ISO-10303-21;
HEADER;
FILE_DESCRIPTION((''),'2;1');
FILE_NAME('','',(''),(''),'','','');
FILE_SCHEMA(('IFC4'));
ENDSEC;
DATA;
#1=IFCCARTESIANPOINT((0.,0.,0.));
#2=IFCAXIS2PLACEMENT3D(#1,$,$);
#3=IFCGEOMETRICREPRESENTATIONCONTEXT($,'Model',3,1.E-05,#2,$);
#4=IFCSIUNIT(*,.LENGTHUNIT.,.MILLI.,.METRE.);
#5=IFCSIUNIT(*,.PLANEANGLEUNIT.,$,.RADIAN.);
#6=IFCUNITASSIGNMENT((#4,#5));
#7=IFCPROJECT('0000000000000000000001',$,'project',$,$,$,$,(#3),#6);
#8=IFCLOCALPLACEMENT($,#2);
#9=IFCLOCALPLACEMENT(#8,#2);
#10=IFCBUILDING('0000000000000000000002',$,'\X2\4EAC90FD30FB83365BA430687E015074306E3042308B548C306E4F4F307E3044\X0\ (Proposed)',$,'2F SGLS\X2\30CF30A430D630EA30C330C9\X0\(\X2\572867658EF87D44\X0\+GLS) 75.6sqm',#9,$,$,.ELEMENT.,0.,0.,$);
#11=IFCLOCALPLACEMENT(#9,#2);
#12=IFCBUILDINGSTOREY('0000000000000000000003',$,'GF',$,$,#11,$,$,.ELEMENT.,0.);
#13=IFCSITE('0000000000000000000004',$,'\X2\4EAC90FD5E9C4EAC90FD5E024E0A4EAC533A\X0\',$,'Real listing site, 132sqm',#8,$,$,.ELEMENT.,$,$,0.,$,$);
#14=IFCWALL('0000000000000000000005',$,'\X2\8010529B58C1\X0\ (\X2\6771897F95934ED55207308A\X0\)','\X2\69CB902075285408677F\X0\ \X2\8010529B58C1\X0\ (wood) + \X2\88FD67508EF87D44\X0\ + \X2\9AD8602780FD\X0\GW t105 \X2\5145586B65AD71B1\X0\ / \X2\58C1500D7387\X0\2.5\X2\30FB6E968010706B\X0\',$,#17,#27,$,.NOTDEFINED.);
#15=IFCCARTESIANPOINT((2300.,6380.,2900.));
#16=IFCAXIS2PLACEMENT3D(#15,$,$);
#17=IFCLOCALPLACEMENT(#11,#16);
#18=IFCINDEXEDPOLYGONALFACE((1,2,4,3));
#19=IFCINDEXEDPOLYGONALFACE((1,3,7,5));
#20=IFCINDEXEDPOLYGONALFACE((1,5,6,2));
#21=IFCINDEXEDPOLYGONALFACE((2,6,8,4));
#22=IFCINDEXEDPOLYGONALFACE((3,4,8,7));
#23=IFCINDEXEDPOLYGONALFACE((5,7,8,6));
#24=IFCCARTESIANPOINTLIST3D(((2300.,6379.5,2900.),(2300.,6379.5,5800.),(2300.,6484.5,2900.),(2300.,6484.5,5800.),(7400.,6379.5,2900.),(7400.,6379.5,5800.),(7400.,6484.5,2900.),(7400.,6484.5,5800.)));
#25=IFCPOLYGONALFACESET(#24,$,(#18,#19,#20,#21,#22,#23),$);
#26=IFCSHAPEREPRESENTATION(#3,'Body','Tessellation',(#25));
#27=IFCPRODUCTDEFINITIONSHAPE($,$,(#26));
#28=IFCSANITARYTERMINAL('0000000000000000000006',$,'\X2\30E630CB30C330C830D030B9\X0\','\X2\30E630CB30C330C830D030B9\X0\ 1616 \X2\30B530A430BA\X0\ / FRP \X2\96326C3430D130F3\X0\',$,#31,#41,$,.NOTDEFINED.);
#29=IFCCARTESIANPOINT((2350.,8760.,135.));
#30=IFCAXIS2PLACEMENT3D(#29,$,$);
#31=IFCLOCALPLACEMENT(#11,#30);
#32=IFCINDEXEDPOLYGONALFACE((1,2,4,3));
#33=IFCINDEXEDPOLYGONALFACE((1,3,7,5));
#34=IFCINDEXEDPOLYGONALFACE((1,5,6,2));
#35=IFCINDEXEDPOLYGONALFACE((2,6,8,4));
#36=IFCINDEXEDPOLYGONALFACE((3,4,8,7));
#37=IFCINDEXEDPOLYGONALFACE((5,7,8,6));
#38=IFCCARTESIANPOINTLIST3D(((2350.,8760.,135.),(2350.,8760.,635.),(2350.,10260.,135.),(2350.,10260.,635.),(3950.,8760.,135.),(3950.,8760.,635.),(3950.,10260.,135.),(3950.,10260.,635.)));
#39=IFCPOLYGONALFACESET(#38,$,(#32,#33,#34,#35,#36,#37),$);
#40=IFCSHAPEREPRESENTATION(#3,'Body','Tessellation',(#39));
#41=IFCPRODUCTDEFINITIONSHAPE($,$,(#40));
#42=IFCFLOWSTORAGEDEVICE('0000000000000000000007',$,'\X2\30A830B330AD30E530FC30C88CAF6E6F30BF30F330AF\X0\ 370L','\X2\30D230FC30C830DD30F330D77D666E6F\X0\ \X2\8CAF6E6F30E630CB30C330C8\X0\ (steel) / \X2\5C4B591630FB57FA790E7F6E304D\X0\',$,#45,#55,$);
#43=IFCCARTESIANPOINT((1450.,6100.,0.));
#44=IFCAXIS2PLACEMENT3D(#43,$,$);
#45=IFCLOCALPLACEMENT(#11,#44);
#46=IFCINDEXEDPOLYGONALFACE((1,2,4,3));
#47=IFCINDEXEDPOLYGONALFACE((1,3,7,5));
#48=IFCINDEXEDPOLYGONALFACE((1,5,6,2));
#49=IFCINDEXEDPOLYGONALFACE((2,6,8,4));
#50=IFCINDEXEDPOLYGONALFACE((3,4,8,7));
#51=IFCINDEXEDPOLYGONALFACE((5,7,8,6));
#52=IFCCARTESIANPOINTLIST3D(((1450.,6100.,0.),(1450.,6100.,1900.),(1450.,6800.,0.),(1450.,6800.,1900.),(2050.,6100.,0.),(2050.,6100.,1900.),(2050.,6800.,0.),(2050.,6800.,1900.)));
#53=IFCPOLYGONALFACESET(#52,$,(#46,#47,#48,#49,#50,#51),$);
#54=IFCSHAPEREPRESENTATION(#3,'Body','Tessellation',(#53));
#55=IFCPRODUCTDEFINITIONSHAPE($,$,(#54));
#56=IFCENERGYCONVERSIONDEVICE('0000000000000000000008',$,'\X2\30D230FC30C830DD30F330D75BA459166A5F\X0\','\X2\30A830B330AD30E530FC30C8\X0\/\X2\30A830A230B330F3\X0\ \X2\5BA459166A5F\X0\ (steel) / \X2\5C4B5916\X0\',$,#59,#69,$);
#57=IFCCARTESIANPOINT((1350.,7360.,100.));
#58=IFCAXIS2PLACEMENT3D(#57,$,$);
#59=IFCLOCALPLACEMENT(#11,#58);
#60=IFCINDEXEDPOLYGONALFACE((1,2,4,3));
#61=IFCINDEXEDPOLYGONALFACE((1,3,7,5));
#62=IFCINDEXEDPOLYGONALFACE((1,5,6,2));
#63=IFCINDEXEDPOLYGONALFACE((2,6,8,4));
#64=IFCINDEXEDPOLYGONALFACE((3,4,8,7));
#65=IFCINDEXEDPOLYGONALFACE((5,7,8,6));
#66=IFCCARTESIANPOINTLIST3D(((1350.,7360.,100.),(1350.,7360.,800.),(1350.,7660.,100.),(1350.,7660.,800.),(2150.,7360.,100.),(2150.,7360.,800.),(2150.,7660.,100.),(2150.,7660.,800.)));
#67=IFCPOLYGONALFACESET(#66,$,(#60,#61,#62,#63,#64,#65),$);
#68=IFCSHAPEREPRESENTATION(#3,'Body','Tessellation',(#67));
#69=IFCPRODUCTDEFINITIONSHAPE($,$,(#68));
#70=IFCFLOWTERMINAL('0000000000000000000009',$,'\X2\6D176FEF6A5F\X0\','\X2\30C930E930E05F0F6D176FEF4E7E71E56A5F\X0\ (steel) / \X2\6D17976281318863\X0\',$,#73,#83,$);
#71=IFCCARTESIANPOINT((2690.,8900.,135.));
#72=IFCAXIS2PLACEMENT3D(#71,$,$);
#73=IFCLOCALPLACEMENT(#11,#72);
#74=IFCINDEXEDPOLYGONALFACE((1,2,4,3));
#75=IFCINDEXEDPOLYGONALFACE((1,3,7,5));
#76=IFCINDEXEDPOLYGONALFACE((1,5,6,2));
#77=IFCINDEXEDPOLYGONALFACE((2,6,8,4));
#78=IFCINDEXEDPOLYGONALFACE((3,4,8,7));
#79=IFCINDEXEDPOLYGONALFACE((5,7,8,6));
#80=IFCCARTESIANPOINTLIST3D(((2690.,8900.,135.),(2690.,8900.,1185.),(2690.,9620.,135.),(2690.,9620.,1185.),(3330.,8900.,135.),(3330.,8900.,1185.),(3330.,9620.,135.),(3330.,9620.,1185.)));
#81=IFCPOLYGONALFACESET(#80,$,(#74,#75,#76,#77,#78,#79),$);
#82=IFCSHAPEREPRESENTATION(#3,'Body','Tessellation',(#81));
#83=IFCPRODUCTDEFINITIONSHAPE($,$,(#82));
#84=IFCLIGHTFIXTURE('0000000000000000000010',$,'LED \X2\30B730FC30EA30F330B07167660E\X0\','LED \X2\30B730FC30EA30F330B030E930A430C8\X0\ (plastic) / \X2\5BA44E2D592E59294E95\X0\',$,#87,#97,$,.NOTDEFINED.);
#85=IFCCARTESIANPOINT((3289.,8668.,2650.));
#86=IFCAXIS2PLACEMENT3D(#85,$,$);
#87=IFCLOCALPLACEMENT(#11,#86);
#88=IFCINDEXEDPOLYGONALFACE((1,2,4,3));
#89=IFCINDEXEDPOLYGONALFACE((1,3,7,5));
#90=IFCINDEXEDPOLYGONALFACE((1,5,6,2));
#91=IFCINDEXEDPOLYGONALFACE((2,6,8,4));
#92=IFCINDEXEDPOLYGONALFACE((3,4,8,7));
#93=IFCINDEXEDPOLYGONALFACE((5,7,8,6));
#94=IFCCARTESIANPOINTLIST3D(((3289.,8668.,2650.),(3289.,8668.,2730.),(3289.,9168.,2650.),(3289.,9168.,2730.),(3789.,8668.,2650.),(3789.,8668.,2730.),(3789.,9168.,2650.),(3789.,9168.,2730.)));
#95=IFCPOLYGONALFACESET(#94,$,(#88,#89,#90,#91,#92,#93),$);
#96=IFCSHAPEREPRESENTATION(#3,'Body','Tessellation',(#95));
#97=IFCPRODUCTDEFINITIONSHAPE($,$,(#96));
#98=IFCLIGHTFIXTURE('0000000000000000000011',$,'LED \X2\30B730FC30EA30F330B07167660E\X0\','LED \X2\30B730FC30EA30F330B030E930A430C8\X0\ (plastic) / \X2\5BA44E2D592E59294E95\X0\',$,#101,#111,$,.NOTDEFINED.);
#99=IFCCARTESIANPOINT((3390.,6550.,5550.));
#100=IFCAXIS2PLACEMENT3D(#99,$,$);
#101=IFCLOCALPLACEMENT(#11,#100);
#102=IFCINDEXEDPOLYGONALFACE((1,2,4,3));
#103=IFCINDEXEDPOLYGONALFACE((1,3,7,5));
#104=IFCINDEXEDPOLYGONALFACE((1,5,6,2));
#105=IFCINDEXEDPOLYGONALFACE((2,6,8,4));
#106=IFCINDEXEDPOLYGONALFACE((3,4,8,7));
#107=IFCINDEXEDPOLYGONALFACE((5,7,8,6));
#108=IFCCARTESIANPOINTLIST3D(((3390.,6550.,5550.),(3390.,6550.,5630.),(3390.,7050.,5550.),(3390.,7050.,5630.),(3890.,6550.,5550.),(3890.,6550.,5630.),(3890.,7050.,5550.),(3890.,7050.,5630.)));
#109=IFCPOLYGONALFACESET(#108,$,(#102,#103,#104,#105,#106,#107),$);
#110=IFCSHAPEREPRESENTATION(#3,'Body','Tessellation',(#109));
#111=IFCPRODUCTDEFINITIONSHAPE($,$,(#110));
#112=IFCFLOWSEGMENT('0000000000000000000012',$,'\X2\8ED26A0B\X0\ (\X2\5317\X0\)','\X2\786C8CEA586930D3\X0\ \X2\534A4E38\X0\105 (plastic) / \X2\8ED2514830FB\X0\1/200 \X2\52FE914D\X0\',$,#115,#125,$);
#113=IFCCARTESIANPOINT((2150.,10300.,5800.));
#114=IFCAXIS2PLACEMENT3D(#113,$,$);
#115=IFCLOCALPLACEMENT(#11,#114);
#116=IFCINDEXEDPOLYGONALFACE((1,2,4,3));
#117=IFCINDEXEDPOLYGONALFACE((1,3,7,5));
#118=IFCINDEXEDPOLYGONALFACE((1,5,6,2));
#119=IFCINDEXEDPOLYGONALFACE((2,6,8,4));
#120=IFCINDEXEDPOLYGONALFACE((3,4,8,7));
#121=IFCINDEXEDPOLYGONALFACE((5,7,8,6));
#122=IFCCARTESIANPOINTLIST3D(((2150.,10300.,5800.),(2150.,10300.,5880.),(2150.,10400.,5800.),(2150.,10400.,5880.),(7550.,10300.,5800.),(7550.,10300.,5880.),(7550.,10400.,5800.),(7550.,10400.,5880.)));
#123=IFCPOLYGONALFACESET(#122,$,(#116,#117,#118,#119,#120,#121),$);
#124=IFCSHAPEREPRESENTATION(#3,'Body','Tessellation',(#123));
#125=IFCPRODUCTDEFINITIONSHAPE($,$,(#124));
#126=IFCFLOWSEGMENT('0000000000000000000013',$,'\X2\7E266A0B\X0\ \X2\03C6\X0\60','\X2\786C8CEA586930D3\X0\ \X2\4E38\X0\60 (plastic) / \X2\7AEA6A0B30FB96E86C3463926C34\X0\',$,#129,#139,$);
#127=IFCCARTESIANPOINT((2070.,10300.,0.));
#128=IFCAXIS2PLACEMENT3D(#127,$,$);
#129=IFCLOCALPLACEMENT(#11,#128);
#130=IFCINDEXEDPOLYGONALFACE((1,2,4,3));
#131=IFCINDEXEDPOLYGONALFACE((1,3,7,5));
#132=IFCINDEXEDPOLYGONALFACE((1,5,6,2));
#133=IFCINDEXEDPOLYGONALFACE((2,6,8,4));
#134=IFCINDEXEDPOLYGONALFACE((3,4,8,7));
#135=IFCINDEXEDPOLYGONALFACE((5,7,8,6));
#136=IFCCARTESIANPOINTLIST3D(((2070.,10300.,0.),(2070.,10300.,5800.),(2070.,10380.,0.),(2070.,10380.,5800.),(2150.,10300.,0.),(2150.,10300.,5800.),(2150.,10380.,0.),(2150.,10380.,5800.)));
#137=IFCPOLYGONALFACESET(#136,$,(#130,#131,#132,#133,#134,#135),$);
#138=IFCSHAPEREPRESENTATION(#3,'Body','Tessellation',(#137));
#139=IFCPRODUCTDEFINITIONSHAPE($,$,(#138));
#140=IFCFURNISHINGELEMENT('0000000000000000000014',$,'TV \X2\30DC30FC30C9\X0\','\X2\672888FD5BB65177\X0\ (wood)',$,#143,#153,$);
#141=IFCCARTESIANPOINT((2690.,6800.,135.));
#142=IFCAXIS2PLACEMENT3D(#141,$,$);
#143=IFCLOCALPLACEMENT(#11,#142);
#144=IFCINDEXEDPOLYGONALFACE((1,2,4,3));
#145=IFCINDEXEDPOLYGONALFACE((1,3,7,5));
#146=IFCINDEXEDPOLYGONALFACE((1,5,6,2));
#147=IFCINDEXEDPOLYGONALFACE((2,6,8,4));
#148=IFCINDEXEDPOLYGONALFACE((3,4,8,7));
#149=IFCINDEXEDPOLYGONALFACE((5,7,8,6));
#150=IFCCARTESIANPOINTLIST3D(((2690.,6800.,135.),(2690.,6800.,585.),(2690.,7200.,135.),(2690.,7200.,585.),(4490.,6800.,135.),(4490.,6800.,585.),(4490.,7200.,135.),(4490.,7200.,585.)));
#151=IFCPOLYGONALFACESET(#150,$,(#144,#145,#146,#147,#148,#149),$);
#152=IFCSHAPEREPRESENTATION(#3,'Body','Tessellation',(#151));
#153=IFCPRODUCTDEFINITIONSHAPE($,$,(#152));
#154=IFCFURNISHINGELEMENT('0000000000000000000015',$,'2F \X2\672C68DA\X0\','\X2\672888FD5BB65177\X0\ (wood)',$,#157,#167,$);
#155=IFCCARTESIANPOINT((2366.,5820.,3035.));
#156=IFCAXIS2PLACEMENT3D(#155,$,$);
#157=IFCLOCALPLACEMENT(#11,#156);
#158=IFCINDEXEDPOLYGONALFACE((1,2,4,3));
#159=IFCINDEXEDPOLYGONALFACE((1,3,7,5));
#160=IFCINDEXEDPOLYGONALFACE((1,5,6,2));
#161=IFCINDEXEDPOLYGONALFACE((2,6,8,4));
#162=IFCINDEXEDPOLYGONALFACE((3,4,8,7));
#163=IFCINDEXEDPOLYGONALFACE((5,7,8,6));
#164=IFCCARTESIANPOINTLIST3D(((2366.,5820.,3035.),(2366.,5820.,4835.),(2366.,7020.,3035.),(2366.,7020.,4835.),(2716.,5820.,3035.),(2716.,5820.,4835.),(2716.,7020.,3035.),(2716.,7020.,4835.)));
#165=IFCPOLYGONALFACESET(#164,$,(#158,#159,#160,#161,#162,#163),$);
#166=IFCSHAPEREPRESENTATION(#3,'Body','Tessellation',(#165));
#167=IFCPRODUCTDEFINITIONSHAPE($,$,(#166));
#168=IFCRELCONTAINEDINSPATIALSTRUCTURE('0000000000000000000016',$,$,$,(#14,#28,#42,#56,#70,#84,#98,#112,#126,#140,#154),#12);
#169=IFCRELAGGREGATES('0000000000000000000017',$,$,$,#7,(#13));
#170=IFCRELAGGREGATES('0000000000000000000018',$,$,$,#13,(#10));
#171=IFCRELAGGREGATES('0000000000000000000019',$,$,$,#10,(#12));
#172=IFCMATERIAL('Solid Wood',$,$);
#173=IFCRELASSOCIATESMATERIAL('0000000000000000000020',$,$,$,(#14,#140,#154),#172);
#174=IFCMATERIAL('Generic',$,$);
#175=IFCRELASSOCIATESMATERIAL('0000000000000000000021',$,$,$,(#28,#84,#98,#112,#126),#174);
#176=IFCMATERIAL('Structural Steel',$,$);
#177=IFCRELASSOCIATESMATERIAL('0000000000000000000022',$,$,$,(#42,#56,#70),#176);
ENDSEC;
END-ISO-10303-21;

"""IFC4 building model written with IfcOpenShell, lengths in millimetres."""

from ifc_helpers import new_model, si_unit, frame, frame_2d, origin, place, context, project, spatial, rectangle, extrude, material, element, save


model = new_model("IFC4")

# Units and contexts
model_context = context("Model", 3, precision=1e-05, world=origin())
ifc_project = project(units=[si_unit("LENGTHUNIT", "METRE", prefix="MILLI"), si_unit("PLANEANGLEUNIT", "RADIAN")], contexts=[model_context])

# Site, building, storey
site_placement = place(None, origin())
site = spatial("IfcSite", under=ifc_project, at=site_placement, Name="京都府京都市上京区", ObjectType="Real listing site, 132sqm", CompositionType="ELEMENT", RefElevation=0.0)
building_placement = place(site_placement, origin())
building = spatial("IfcBuilding", under=site, at=building_placement, Name="京都・茶室と縁側のある和の住まい (Proposed)", ObjectType="2F SGLSハイブリッド(在来軸組+GLS) 75.6sqm", CompositionType="ELEMENT", ElevationOfRefHeight=0.0, ElevationOfTerrain=0.0)
storey_placement = place(building_placement, origin())
storey = spatial("IfcBuildingStorey", under=building, at=storey_placement, Name="GF", CompositionType="ELEMENT", Elevation=0.0)

# Shared definitions
ifc_material_1 = material(Name="Solid Wood")

# Wall
wall_1_placement = place(storey_placement, frame((2300.0, 6380.0, 2900.0)))
element("IfcWall", 1, at=wall_1_placement, inside=storey, material=ifc_material_1, Name="耐力壁 (東西間仕切り)", Description="構造用合板 耐力壁 (wood) + 製材軸組 + 高性能GW t105 充填断熱 / 壁倍率2.5・準耐火", PredefinedType="NOTDEFINED", context=model_context, shape_type="SweptSolid", body=[
    extrude(rectangle(XDim=5100.0, YDim=105.0, at=frame_2d((2550.0, 52.0))), frame((2300.0, 6380.0, 2900.0)), (0.0, 0.0, 1.0), 2900.0),
])

# Sanitary terminal
ifc_material_2 = material(Name="Generic")
sanitary_terminal_placement = place(storey_placement, frame((2350.0, 8760.0, 135.0)))
element("IfcSanitaryTerminal", 2, at=sanitary_terminal_placement, inside=storey, material=ifc_material_2, Name="ユニットバス", Description="ユニットバス 1616 サイズ / FRP 防水パン", PredefinedType="NOTDEFINED", context=model_context, shape_type="SweptSolid", body=[
    extrude(rectangle(XDim=1600.0, YDim=1500.0, at=frame_2d((800.0, 750.0))), frame((2350.0, 8760.0, 135.0)), (0.0, 0.0, 1.0), 500.0),
])

# Flow storage device
ifc_material_3 = material(Name="Structural Steel")
flow_storage_device_placement = place(storey_placement, frame((1450.0, 6100.0, 0.0)))
element("IfcFlowStorageDevice", 3, at=flow_storage_device_placement, inside=storey, material=ifc_material_3, Name="エコキュート貯湯タンク 370L", Description="ヒートポンプ給湯 貯湯ユニット (steel) / 屋外・基礎置き", context=model_context, shape_type="SweptSolid", body=[
    extrude(rectangle(XDim=600.0, YDim=700.0, at=frame_2d((300.0, 350.0))), frame((1450.0, 6100.0, 0.0)), (0.0, 0.0, 1.0), 1900.0),
])

# Energy conversion device
energy_conversion_device_placement = place(storey_placement, frame((1350.0, 7360.0, 100.0)))
element("IfcEnergyConversionDevice", 4, at=energy_conversion_device_placement, inside=storey, material=ifc_material_3, Name="ヒートポンプ室外機", Description="エコキュート/エアコン 室外機 (steel) / 屋外", context=model_context, shape_type="SweptSolid", body=[
    extrude(rectangle(XDim=800.0, YDim=300.0, at=frame_2d((400.0, 150.0))), frame((1350.0, 7360.0, 100.0)), (0.0, 0.0, 1.0), 700.0),
])

# Flow terminal
flow_terminal_placement = place(storey_placement, frame((2690.0, 8900.0, 135.0)))
element("IfcFlowTerminal", 5, at=flow_terminal_placement, inside=storey, material=ifc_material_3, Name="洗濯機", Description="ドラム式洗濯乾燥機 (steel) / 洗面脱衣", context=model_context, shape_type="SweptSolid", body=[
    extrude(rectangle(XDim=640.0, YDim=720.0, at=frame_2d((320.0, 360.0))), frame((2690.0, 8900.0, 135.0)), (0.0, 0.0, 1.0), 1050.0),
])

# Light fixtures
light_fixture_1_placement = place(storey_placement, frame((3289.0, 8668.0, 2650.0)))
element("IfcLightFixture", 6, at=light_fixture_1_placement, inside=storey, material=ifc_material_2, Name="LED シーリング照明", Description="LED シーリングライト (plastic) / 室中央天井", PredefinedType="NOTDEFINED", context=model_context, shape_type="SweptSolid", body=[
    extrude(rectangle(XDim=500.0, YDim=500.0, at=frame_2d((250.0, 250.0))), frame((3289.0, 8668.0, 2650.0)), (0.0, 0.0, 1.0), 80.0),
])
light_fixture_2_placement = place(storey_placement, frame((3390.0, 6550.0, 5550.0)))
element("IfcLightFixture", 7, at=light_fixture_2_placement, inside=storey, material=ifc_material_2, Name="LED シーリング照明", Description="LED シーリングライト (plastic) / 室中央天井", PredefinedType="NOTDEFINED", context=model_context, shape_type="SweptSolid", body=[
    extrude(rectangle(XDim=500.0, YDim=500.0, at=frame_2d((250.0, 250.0))), frame((3390.0, 6550.0, 5550.0)), (0.0, 0.0, 1.0), 80.0),
])

# Flow segments
flow_segment_1_placement = place(storey_placement, frame((2150.0, 10300.0, 5800.0)))
element("IfcFlowSegment", 8, at=flow_segment_1_placement, inside=storey, material=ifc_material_2, Name="軒樋 (北)", Description="硬質塩ビ 半丸105 (plastic) / 軒先・1/200 勾配", context=model_context, shape_type="SweptSolid", body=[
    extrude(rectangle(XDim=5400.0, YDim=100.0, at=frame_2d((2700.0, 50.0))), frame((2150.0, 10300.0, 5800.0)), (0.0, 0.0, 1.0), 80.0),
])
flow_segment_2_placement = place(storey_placement, frame((2070.0, 10300.0, 0.0)))
element("IfcFlowSegment", 9, at=flow_segment_2_placement, inside=storey, material=ifc_material_2, Name="縦樋 φ60", Description="硬質塩ビ 丸60 (plastic) / 竪樋・雨水排水", context=model_context, shape_type="SweptSolid", body=[
    extrude(rectangle(XDim=80.0, YDim=80.0, at=frame_2d((40.0, 40.0))), frame((2070.0, 10300.0, 0.0)), (0.0, 0.0, 1.0), 5800.0),
])

# Furnishing elements
furnishing_1_placement = place(storey_placement, frame((2690.0, 6800.0, 135.0)))
element("IfcFurnishingElement", 10, at=furnishing_1_placement, inside=storey, material=ifc_material_1, Name="TV ボード", Description="木製家具 (wood)", context=model_context, shape_type="SweptSolid", body=[
    extrude(rectangle(XDim=1800.0, YDim=400.0, at=frame_2d((900.0, 200.0))), frame((2690.0, 6800.0, 135.0)), (0.0, 0.0, 1.0), 450.0),
])
furnishing_2_placement = place(storey_placement, frame((2366.0, 5820.0, 3035.0)))
element("IfcFurnishingElement", 11, at=furnishing_2_placement, inside=storey, material=ifc_material_1, Name="2F 本棚", Description="木製家具 (wood)", context=model_context, shape_type="SweptSolid", body=[
    extrude(rectangle(XDim=350.0, YDim=1200.0, at=frame_2d((175.0, 600.0))), frame((2366.0, 5820.0, 3035.0)), (0.0, 0.0, 1.0), 1800.0),
])

save(model, "model.ifc")
